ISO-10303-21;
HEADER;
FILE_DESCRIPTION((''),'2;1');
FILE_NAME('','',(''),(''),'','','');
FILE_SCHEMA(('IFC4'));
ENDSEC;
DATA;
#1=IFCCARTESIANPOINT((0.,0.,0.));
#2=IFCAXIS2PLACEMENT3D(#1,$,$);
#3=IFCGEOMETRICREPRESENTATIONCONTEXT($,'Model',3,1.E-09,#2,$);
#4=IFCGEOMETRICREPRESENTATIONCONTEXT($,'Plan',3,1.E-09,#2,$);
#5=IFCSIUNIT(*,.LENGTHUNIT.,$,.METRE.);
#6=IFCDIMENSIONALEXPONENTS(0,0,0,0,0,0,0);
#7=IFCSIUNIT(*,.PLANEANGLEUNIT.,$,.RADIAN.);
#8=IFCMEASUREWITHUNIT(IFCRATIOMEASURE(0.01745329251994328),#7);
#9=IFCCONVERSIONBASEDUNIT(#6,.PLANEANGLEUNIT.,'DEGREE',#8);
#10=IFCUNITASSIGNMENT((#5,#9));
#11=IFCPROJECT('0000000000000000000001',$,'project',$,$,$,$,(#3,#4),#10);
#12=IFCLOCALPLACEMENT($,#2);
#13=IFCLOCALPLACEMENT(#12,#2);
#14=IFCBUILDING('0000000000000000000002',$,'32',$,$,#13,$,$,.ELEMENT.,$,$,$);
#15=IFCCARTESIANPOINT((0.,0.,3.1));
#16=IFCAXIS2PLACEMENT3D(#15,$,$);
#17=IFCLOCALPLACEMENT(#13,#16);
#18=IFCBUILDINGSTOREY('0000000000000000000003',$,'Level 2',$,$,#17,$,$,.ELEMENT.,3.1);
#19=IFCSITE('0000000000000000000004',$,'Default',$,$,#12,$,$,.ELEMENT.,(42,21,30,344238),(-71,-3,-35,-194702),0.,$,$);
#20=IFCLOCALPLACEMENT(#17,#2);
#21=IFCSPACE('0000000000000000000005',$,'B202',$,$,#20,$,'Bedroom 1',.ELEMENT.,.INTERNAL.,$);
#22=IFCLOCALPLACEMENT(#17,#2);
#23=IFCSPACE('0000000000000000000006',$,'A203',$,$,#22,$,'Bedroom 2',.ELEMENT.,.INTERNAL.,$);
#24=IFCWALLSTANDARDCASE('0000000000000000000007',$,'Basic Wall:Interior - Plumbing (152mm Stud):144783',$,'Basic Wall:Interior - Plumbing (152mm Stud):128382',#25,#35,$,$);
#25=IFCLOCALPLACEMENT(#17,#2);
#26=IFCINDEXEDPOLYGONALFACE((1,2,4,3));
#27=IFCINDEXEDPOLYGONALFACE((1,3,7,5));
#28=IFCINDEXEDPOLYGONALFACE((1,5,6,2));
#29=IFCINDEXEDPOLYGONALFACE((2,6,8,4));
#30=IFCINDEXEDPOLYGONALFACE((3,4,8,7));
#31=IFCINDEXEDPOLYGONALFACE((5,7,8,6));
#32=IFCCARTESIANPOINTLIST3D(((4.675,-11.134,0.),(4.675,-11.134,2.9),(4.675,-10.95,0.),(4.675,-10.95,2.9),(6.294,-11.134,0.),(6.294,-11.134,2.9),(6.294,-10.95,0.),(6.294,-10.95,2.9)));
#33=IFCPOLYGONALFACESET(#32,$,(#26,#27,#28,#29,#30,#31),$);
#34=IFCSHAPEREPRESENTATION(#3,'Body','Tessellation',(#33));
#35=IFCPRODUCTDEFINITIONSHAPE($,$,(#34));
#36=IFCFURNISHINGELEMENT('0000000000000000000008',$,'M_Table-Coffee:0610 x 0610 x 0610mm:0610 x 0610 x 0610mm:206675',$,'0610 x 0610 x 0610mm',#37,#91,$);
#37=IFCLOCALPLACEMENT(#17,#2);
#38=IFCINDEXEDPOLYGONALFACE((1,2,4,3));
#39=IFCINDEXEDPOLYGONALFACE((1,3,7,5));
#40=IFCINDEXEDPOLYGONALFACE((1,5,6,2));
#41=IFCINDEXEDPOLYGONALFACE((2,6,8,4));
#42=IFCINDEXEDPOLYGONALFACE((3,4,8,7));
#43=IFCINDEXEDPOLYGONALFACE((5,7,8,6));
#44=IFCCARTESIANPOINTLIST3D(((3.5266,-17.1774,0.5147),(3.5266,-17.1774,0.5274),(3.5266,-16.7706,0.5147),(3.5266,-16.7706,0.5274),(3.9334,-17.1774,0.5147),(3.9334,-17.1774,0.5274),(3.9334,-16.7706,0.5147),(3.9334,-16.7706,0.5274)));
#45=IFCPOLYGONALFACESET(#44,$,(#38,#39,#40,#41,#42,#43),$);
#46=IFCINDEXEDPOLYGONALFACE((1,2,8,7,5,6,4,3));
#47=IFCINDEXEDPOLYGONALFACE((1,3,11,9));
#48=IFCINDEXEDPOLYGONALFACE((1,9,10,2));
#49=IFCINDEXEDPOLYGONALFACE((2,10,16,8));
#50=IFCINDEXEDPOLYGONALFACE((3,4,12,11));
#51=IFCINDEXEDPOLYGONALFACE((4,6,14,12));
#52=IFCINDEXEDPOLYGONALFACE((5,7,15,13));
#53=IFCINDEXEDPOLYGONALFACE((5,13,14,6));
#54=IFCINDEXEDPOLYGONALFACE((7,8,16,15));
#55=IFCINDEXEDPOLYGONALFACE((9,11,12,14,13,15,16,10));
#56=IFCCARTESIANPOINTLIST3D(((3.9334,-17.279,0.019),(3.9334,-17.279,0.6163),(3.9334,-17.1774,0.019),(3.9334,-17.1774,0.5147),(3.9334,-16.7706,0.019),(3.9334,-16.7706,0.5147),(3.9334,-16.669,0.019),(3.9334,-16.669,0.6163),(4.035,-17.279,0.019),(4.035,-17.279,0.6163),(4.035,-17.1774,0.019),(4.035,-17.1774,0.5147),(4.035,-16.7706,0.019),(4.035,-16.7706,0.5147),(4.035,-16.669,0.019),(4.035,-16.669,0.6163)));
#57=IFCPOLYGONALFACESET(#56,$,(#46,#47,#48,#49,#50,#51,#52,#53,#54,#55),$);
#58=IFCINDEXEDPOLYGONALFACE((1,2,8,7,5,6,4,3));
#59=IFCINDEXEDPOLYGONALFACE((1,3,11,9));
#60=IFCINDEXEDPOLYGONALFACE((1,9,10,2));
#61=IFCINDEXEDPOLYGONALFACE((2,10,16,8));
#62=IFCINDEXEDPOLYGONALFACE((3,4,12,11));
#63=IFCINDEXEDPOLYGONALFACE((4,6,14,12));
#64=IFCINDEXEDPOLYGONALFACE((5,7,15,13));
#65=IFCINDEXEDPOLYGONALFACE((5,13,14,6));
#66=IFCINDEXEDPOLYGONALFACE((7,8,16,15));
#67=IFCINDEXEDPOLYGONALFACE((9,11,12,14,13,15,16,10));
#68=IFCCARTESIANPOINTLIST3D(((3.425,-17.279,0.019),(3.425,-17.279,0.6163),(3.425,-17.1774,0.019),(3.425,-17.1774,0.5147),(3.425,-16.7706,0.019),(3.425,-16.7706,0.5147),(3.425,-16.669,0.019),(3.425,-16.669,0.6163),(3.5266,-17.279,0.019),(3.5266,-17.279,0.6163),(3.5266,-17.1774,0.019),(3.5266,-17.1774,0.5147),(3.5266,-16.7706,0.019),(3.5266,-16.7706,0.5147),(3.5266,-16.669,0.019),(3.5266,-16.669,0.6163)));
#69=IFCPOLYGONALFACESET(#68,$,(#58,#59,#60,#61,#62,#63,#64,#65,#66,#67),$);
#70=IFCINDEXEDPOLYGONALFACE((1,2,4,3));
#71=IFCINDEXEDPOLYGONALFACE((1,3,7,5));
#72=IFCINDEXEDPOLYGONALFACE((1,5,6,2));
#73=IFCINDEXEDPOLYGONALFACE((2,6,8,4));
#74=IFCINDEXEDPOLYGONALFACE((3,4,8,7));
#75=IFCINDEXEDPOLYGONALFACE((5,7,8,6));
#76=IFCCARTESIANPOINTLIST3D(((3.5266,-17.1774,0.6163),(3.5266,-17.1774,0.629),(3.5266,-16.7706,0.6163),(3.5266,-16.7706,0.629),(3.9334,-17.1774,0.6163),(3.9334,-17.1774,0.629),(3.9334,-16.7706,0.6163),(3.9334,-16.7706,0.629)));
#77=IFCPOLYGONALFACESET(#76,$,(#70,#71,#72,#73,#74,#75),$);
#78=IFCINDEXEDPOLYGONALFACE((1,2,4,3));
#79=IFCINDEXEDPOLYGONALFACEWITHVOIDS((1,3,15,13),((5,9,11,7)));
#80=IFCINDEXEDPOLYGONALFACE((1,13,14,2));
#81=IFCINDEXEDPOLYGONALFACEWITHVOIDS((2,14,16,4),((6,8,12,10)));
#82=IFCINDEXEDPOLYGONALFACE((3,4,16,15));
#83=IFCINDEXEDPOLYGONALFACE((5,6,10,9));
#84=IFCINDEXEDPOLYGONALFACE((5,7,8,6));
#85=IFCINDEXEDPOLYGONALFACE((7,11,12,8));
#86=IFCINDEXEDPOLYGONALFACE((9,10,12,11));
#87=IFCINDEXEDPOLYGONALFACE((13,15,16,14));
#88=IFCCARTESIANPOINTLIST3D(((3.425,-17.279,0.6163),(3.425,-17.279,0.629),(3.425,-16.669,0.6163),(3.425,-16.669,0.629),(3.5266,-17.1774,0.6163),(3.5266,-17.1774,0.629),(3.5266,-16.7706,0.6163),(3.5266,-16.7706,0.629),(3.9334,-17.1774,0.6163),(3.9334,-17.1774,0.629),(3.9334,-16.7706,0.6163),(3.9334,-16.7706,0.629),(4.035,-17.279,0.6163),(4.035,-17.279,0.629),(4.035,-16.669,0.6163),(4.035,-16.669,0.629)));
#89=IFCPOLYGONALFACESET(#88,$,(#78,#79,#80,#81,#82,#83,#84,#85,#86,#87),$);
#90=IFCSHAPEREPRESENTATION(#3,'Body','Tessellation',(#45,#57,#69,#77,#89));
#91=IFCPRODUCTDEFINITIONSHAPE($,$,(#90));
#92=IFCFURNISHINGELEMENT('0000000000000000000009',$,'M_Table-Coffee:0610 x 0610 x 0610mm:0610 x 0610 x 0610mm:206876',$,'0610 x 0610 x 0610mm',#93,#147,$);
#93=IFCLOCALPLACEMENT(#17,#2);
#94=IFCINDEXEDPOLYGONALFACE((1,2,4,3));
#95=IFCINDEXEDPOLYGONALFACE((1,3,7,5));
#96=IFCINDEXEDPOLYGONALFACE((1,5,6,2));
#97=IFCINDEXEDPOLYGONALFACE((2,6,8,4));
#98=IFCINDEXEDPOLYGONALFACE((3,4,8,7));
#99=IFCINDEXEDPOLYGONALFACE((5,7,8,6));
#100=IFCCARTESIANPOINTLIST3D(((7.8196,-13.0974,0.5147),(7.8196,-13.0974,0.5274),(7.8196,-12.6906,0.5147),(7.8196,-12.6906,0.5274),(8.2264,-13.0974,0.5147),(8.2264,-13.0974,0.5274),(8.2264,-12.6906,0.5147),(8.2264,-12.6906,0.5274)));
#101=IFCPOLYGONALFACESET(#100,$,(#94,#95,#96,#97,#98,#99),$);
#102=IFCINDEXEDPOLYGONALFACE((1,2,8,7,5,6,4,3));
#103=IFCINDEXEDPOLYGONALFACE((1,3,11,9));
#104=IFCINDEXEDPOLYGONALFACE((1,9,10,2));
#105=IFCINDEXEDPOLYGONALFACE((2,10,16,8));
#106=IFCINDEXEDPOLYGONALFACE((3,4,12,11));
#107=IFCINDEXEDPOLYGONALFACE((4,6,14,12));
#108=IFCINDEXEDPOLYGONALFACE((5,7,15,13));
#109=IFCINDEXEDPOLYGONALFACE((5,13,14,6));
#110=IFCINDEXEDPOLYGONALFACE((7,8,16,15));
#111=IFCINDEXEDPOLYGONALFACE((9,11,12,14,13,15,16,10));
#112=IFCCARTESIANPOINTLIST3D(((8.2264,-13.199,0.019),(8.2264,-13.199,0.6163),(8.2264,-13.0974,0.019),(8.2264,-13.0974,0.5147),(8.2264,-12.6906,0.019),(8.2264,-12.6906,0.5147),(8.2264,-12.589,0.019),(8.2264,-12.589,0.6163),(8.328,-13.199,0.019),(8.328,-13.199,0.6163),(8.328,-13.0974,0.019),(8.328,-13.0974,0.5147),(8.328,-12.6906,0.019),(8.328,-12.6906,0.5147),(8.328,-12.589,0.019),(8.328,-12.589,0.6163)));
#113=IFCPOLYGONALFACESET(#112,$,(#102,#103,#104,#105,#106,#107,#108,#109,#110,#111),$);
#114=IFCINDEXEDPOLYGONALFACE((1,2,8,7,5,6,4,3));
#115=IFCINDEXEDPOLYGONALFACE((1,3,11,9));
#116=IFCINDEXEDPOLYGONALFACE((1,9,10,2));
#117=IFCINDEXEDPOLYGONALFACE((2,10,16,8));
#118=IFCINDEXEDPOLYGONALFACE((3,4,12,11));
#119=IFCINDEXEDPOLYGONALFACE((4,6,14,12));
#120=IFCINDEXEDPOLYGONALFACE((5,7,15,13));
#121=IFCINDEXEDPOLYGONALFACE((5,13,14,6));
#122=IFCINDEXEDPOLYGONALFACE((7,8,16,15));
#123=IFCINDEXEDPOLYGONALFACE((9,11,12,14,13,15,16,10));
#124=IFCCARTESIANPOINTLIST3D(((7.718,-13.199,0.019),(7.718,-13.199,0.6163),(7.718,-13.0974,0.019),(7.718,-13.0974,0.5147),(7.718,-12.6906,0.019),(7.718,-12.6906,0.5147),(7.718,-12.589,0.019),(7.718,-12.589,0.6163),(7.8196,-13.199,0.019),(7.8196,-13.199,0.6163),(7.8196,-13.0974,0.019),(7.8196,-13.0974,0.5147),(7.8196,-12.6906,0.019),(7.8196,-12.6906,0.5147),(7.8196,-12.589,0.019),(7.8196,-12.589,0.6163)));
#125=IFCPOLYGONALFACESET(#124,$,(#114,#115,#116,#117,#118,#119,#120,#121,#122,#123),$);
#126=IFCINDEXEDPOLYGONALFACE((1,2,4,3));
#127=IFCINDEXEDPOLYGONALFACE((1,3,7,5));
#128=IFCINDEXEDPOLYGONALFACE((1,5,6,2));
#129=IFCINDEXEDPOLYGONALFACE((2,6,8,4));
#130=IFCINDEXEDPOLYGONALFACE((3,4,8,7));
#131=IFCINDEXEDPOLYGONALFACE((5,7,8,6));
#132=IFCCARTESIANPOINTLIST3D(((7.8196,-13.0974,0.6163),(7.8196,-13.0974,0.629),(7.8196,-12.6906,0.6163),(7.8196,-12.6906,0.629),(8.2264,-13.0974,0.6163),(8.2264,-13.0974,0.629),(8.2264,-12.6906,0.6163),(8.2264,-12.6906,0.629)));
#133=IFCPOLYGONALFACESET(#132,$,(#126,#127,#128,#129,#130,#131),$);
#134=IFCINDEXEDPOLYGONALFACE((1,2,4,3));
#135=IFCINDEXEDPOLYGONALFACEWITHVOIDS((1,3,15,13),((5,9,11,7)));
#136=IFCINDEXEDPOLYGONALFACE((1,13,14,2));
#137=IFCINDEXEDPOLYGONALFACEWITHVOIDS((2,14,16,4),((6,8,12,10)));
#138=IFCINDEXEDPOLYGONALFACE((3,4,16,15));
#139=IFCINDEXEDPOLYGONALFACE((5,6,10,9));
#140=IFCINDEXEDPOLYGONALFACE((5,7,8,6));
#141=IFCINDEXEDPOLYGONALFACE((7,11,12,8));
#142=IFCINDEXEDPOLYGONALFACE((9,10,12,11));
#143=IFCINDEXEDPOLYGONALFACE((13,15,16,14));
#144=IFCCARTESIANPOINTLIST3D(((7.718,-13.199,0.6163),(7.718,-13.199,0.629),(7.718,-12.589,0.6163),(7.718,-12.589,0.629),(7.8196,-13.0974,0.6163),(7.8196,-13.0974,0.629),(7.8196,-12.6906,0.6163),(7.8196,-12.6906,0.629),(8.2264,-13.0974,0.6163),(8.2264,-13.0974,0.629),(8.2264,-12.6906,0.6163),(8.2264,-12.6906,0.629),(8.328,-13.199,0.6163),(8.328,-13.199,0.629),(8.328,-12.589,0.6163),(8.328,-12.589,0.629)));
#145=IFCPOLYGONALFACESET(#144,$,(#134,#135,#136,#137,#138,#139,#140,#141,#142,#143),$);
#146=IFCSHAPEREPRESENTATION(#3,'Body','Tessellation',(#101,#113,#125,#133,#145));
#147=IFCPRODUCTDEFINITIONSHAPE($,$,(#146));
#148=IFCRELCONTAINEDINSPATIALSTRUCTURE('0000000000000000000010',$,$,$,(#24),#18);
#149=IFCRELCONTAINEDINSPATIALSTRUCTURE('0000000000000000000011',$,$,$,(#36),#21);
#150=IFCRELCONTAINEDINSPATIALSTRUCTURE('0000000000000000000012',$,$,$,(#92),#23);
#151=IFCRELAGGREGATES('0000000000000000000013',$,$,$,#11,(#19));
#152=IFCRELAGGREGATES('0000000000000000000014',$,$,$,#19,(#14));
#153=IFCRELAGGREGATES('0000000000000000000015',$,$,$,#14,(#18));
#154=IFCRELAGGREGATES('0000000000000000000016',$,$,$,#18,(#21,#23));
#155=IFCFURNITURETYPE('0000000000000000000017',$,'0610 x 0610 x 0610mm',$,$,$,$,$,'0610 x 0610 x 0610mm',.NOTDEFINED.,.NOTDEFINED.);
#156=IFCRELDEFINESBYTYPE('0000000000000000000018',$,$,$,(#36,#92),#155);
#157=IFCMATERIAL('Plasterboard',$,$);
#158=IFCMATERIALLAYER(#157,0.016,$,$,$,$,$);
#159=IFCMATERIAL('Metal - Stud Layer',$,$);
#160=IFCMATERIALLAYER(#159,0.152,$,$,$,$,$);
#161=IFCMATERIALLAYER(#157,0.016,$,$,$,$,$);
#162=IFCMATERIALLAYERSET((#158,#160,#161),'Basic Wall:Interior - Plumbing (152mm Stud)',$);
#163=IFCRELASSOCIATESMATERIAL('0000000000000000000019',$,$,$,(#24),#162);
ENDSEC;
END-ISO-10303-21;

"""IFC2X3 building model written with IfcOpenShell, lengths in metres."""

from ifc_helpers import new_model, entity, si_unit, converted_unit, frame, frame_2d, origin, origin_2d_with_axis, place, context, project, spatial, polyline, rectangle, outline, extrude, source, transform, mapped, material, layer, layer_set, layer_usage, type_object, type_shapes, element, save


model = new_model("IFC2X3")

# Units and contexts
model_context = context("Model", 3, precision=1e-09, world=origin())
plan_context = context("Plan", 3, precision=1e-09, world=origin())
ifc_project = project(units=[si_unit("LENGTHUNIT", "METRE"), converted_unit("PLANEANGLEUNIT", "DEGREE", entity("IfcRatioMeasure", 0.01745329251994328), si_unit("PLANEANGLEUNIT", "RADIAN"), dimensions=[0, 0, 0, 0, 0, 0, 0])], contexts=[model_context, plan_context])

# Site, building, storey
site_placement = place(None, origin())
site = spatial("IfcSite", under=ifc_project, at=site_placement, Name="Default", CompositionType="ELEMENT", RefLatitude=(42, 21, 30, 344238), RefLongitude=(-71, -3, -35, -194702), RefElevation=0.0)
building_placement = place(site_placement, origin())
building = spatial("IfcBuilding", under=site, at=building_placement, Name="32", CompositionType="ELEMENT")
storey_placement = place(building_placement, frame((0.0, 0.0, 3.1)))
storey = spatial("IfcBuildingStorey", under=building, at=storey_placement, Name="Level 2", CompositionType="ELEMENT", Elevation=3.1)

# Shared definitions
ifc_material_1 = material(Name="Metal - Stud Layer")
ifc_material_2 = material(Name="Plasterboard")

# Wall
ifc_layer_1 = layer(ifc_material_2, 0.016)
ifc_layer_2 = layer(ifc_material_1, 0.152)
ifc_layer_3 = layer(ifc_material_2, 0.016)
ifc_layer_set_1 = layer_set([ifc_layer_1, ifc_layer_2, ifc_layer_3], Name="Basic Wall:Interior - Plumbing (152mm Stud)")
ifc_layer_usage_1 = layer_usage(ifc_layer_set_1, "AXIS2", "NEGATIVE", 0.092)
wall_1_placement = place(storey_placement, frame((6.294, -11.042, 0.0), z_axis=(0.0, 0.0, 1.0), x_axis=(-1.0, 0.0, 0.0)))
element("IfcWallStandardCase", 1, at=wall_1_placement, inside=storey, material=ifc_layer_usage_1, Name="Basic Wall:Interior - Plumbing (152mm Stud):144783", ObjectType="Basic Wall:Interior - Plumbing (152mm Stud):128382", context=model_context, shape_type="SweptSolid", body=[
    extrude(rectangle(XDim=1.619, YDim=0.184, at=frame_2d((0.8095, 0.0), x_axis=(-1.0, 0.0))), origin(), (0.0, 0.0, 1.0), 2.9),
])

# Shared definitions
space_1_placement = place(storey_placement, origin())
space_1 = spatial("IfcSpace", under=storey, at=space_1_placement, Name="B202", LongName="Bedroom 1", CompositionType="ELEMENT", InteriorOrExteriorSpace="INTERNAL")

# Furnishing element
furniture_type = type_object("IfcFurnitureType", Name="0610 x 0610 x 0610mm", ElementType="0610 x 0610 x 0610mm", AssemblyPlace="NOTDEFINED")
shared_shape_1 = source(origin(), model_context, "Body", "SweptSolid", [
    extrude(rectangle(XDim=0.4068, YDim=0.4068, at=origin_2d_with_axis()), frame((0.0183, 0.0952, 0.4957), z_axis=(0.0, 0.0, 1.0), x_axis=(-1.0, 0.0, 0.0)), (0.0, 0.0, 1.0), 0.0127),
    extrude(outline(polyline([(-0.2732, -0.305), (0.324, -0.305), (0.324, 0.305), (-0.2732, 0.305), (-0.2732, 0.2034), (0.2225, 0.2034), (0.2225, -0.2034), (-0.2732, -0.2034), (-0.2732, -0.305)])), frame((0.2217, 0.0952, 0.2732), z_axis=(1.0, 0.0, 0.0), x_axis=(0.0, 0.0, 1.0)), (0.0, 0.0, 1.0), 0.1016),
    extrude(outline(polyline([(-0.305, -0.3241), (0.305, -0.3241), (0.305, 0.2733), (0.2034, 0.2733), (0.2034, -0.2224), (-0.2034, -0.2224), (-0.2034, 0.2733), (-0.305, 0.2733), (-0.305, -0.3241)])), frame((-0.2867, 0.0952, 0.2733), z_axis=(1.0, 0.0, 0.0), x_axis=(0.0, -1.0, 0.0)), (0.0, 0.0, 1.0), 0.1016),
    extrude(rectangle(XDim=0.4068, YDim=0.4068, at=origin_2d_with_axis()), frame((0.0183, 0.0952, 0.5973), z_axis=(0.0, 0.0, 1.0), x_axis=(-1.0, 0.0, 0.0)), (0.0, 0.0, 1.0), 0.0127),
    extrude(outline(polyline([(-0.305, -0.305), (0.305, -0.305), (0.305, 0.305), (-0.305, 0.305), (-0.305, -0.305)]), holes=[polyline([(-0.2034, -0.2034), (-0.2034, 0.2034), (0.2034, 0.2034), (0.2034, -0.2034), (-0.2034, -0.2034)])]), frame((0.0183, 0.0952, 0.5973), z_axis=(0.0, 0.0, 1.0), x_axis=(-1.0, 0.0, 0.0)), (0.0, 0.0, 1.0), 0.0127),
])
type_shapes(furniture_type, [shared_shape_1])
furnishing_1_placement = place(space_1_placement, frame((3.7117, -17.0692, 0.019)))
element("IfcFurnishingElement", 2, at=furnishing_1_placement, inside=space_1, type_object=furniture_type, Name="M_Table-Coffee:0610 x 0610 x 0610mm:0610 x 0610 x 0610mm:206675", ObjectType="0610 x 0610 x 0610mm", context=model_context, shape_type="MappedRepresentation", body=[
    mapped(shared_shape_1, transform((0.0, 0.0, 0.0), scale=1.0)),
])

# Shared definitions
space_2_placement = place(storey_placement, origin())
space_2 = spatial("IfcSpace", under=storey, at=space_2_placement, Name="A203", LongName="Bedroom 2", CompositionType="ELEMENT", InteriorOrExteriorSpace="INTERNAL")

# Furnishing element
furnishing_2_placement = place(space_2_placement, frame((8.0047, -12.9892, 0.019)))
element("IfcFurnishingElement", 3, at=furnishing_2_placement, inside=space_2, type_object=furniture_type, Name="M_Table-Coffee:0610 x 0610 x 0610mm:0610 x 0610 x 0610mm:206876", ObjectType="0610 x 0610 x 0610mm", context=model_context, shape_type="MappedRepresentation", body=[
    mapped(shared_shape_1, transform((0.0, 0.0, 0.0), scale=1.0)),
])

save(model, "model.ifc")
